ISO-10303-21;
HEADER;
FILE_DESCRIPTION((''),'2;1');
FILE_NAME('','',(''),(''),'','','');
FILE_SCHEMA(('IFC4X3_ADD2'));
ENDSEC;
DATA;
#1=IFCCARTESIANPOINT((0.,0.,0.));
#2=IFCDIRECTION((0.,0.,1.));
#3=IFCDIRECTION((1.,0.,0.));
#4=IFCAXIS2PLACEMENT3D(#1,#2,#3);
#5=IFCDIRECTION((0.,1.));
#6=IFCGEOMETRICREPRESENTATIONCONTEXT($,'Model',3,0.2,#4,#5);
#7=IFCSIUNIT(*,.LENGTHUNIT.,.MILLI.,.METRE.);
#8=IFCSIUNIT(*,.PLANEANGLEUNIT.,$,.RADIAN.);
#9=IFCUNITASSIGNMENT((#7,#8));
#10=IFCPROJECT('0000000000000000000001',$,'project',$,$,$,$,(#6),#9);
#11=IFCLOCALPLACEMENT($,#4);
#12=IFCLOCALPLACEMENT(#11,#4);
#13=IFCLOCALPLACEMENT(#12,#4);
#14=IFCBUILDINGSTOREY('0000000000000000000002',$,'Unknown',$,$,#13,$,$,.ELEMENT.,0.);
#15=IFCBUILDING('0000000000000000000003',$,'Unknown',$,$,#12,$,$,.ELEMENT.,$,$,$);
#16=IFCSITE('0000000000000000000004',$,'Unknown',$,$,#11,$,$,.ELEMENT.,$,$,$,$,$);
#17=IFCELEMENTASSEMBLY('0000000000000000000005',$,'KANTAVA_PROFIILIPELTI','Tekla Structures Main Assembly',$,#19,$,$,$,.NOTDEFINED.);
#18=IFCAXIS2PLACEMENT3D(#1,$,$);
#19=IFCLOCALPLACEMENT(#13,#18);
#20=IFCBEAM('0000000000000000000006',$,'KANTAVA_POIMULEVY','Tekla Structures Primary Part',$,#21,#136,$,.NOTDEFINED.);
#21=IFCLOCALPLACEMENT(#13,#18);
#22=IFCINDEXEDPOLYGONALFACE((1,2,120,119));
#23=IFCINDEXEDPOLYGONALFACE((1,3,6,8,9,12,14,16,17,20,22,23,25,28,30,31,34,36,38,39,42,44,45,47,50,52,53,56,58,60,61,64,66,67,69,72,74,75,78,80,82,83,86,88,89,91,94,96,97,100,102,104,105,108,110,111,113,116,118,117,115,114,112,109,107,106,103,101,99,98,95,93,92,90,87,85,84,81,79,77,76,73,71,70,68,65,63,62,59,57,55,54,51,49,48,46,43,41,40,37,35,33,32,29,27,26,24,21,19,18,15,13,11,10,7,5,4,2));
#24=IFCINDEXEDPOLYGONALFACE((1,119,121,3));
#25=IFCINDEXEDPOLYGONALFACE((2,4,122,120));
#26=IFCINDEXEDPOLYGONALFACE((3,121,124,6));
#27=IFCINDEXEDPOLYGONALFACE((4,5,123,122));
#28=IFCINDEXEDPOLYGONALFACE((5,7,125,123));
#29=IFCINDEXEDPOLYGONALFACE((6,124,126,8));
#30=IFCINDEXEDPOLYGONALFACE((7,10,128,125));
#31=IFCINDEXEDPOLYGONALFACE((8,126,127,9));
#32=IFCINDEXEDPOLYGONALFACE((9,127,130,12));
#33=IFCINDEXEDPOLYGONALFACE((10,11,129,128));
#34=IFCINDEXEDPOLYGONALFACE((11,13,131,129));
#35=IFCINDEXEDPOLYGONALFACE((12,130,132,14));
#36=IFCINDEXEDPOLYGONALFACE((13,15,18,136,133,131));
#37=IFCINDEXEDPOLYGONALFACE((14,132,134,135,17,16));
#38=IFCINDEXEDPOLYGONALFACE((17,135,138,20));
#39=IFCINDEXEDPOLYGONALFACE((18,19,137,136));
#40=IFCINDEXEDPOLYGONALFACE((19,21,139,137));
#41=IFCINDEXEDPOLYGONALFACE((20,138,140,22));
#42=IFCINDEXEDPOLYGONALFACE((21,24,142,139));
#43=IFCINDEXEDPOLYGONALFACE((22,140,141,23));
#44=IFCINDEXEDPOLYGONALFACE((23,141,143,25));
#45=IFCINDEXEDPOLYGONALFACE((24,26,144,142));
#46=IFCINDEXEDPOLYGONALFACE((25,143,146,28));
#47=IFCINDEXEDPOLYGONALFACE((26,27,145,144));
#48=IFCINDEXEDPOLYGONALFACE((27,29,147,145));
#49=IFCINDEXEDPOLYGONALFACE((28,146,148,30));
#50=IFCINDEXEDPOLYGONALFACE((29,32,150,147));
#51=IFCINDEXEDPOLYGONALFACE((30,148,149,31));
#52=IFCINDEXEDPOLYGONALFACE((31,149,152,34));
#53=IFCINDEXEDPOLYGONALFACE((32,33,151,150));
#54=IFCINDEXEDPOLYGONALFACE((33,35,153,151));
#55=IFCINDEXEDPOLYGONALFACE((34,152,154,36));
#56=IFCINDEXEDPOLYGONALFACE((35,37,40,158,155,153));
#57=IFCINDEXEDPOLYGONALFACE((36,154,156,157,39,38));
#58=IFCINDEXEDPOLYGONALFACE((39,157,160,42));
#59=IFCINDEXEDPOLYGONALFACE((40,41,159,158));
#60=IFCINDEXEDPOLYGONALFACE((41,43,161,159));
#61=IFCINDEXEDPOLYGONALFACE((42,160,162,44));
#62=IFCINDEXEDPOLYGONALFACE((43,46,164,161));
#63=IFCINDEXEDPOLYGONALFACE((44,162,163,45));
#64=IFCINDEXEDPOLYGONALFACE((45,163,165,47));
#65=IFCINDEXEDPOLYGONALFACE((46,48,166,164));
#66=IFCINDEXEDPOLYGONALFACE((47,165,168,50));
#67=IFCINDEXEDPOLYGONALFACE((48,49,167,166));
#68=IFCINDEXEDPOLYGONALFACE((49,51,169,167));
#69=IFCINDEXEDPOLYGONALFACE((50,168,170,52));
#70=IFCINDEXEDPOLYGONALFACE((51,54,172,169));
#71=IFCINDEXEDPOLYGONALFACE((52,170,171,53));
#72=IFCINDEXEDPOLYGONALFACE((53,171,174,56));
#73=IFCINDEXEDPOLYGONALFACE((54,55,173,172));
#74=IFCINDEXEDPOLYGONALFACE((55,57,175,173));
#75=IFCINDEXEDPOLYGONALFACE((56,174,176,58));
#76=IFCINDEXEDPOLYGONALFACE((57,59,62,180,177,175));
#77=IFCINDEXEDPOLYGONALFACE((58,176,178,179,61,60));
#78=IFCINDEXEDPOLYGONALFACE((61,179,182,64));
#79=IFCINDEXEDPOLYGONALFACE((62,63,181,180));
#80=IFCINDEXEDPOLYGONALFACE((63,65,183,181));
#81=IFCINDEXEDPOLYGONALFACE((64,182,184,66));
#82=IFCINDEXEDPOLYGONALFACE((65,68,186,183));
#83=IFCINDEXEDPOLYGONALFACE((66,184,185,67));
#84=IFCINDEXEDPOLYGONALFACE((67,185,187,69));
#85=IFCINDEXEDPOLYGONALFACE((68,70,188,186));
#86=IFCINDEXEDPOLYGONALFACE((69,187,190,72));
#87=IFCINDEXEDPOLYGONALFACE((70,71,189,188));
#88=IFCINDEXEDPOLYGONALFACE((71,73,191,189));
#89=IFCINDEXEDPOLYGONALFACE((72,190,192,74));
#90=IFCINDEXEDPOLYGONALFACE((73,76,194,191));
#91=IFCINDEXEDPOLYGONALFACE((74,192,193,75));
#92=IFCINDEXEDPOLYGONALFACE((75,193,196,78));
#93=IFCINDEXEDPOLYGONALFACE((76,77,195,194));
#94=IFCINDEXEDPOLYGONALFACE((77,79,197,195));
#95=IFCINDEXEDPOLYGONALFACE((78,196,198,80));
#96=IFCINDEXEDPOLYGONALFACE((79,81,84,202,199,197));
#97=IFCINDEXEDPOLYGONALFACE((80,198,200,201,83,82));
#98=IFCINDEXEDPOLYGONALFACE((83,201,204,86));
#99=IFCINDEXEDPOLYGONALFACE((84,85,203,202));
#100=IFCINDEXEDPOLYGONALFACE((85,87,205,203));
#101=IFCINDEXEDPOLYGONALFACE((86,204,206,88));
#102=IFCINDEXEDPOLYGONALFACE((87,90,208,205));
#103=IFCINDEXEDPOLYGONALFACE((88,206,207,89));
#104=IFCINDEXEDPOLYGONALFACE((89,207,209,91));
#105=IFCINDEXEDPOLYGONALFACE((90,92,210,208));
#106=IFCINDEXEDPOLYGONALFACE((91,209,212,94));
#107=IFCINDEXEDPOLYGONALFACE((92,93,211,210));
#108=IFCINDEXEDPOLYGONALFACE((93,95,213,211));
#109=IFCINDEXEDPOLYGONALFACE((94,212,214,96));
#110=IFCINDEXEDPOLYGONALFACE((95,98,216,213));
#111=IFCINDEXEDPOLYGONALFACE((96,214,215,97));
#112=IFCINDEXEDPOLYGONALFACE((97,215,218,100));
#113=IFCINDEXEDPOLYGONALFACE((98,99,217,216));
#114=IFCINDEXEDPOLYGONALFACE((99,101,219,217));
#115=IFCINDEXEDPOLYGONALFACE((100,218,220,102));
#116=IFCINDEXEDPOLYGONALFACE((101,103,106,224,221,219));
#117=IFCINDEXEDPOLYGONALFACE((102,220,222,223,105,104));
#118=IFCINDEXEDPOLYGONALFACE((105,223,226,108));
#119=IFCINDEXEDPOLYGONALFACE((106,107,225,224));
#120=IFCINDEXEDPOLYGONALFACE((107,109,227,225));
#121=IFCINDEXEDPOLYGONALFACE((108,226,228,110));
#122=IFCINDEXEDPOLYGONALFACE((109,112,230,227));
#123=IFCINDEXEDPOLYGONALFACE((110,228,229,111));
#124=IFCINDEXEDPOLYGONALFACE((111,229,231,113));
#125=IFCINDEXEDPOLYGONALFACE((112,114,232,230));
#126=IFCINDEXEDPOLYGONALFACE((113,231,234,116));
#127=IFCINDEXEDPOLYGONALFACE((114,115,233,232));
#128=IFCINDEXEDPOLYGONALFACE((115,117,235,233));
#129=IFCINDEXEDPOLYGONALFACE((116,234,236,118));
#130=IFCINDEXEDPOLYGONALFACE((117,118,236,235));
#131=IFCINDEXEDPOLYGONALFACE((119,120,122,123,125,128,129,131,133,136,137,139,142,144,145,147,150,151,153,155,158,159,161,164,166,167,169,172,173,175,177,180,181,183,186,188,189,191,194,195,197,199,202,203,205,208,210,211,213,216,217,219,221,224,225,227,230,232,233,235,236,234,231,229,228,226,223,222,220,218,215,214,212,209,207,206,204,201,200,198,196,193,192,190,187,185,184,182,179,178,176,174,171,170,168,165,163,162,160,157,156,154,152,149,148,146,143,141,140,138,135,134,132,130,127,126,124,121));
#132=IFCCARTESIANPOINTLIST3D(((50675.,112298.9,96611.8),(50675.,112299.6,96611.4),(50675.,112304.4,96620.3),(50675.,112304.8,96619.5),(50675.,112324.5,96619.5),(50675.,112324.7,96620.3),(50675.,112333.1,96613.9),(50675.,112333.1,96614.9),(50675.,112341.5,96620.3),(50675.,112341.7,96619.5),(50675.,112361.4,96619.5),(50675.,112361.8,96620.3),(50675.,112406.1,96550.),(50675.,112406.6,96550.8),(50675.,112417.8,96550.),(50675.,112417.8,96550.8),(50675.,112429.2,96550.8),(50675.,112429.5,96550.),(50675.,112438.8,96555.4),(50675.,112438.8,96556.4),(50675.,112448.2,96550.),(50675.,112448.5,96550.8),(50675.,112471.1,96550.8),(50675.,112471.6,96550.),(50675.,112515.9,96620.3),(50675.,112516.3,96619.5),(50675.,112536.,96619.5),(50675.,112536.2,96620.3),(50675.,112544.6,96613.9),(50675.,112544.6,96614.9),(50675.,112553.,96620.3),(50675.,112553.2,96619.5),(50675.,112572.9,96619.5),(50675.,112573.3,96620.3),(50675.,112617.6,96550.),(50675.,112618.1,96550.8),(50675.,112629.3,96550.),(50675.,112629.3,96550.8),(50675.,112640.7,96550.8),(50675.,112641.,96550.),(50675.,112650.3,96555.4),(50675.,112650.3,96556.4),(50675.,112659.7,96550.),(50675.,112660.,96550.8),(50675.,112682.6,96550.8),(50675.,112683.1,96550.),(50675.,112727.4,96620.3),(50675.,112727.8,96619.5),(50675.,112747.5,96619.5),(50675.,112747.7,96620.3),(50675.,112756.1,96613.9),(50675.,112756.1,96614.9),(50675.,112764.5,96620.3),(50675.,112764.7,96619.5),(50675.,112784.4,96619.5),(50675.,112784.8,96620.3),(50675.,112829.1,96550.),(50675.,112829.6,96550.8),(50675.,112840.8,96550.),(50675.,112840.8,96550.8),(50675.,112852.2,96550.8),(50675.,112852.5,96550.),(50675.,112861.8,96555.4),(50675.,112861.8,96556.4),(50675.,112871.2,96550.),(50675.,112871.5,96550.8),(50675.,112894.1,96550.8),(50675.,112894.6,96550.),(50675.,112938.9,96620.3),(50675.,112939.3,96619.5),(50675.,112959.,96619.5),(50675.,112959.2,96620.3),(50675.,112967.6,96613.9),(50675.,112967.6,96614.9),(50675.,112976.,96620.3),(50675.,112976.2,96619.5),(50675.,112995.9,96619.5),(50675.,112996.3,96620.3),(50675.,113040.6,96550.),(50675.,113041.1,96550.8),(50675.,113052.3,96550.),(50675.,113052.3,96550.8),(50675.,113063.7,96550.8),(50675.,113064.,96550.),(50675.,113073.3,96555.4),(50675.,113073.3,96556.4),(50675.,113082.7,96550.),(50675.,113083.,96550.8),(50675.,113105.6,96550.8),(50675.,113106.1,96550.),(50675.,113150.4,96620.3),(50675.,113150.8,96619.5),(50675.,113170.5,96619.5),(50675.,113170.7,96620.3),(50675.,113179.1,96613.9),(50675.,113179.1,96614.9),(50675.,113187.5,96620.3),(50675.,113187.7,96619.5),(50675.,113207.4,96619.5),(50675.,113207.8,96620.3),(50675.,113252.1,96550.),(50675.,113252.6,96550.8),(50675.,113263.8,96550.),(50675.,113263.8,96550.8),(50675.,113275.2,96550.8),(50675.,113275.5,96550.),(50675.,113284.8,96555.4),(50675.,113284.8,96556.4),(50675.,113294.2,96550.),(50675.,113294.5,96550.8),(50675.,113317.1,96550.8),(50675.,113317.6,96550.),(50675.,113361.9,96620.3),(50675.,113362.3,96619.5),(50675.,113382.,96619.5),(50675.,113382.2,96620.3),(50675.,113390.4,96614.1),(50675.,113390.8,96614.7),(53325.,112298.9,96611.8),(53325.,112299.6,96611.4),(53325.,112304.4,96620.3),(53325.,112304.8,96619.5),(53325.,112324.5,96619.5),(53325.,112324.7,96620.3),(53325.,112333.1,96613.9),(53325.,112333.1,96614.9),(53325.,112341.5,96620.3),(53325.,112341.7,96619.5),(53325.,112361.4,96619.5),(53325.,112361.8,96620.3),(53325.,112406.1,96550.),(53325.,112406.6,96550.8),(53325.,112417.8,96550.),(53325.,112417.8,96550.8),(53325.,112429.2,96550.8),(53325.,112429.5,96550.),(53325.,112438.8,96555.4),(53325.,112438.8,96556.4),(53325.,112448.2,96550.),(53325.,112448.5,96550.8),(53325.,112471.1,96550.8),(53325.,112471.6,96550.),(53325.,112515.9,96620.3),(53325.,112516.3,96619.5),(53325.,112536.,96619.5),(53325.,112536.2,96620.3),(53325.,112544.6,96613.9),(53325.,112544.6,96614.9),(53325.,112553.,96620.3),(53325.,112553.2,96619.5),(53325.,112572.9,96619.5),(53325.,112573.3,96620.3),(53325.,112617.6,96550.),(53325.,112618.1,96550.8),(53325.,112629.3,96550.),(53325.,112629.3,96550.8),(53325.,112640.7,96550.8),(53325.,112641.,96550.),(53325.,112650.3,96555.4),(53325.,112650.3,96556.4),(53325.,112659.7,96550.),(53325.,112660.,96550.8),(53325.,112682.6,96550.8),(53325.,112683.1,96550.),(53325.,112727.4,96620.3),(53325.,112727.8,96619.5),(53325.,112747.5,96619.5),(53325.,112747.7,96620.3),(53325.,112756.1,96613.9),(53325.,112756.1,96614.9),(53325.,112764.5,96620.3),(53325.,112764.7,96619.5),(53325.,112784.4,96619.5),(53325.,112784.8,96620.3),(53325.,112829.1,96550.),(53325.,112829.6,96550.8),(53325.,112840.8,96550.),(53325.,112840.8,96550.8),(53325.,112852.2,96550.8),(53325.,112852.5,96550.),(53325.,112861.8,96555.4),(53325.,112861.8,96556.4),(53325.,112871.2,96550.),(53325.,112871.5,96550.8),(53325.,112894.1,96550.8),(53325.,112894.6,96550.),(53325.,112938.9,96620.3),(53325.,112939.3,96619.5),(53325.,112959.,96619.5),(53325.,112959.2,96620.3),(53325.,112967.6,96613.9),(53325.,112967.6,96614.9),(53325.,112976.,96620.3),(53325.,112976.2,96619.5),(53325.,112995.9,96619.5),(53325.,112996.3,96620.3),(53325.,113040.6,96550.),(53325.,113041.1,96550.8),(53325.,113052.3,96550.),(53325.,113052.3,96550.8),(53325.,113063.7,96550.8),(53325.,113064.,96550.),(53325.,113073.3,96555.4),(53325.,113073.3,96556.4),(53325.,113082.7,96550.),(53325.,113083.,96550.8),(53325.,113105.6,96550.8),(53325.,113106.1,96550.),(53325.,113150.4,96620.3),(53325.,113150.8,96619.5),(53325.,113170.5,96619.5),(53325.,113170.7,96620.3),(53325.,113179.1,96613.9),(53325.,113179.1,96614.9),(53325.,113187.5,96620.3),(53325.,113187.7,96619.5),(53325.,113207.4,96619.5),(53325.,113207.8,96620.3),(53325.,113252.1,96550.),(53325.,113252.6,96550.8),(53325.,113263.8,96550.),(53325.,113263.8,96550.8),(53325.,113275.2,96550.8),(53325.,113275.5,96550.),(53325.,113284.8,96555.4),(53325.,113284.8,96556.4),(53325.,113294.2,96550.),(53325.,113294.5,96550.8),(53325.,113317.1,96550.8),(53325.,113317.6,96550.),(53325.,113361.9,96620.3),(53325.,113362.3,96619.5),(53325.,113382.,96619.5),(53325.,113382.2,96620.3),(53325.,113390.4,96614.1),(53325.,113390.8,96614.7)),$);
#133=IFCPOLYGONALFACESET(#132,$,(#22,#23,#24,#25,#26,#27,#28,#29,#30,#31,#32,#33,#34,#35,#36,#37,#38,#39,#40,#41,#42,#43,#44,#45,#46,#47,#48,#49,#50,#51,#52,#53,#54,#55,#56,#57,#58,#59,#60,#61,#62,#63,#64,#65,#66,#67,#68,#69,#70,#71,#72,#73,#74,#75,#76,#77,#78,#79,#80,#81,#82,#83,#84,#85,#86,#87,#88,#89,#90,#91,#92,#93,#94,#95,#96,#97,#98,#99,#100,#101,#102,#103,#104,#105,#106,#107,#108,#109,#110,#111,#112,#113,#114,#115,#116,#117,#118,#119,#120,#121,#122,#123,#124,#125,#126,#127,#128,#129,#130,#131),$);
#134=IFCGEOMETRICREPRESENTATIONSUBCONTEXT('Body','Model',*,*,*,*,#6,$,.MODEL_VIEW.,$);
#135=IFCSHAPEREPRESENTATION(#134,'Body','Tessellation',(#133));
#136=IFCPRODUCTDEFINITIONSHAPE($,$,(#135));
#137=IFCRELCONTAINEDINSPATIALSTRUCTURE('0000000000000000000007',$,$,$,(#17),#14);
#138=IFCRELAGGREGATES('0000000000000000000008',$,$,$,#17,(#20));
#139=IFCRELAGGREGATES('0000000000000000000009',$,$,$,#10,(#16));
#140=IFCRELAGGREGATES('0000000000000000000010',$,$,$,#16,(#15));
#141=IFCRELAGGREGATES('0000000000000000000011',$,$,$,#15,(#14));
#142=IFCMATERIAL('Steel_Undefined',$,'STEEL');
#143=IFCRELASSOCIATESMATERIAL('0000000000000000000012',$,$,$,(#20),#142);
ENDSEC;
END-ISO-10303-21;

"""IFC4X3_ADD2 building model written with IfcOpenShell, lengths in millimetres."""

from ifc_helpers import new_model, si_unit, direction, frame, origin_with_axes, place, context, subcontext, project, spatial, line, indexed_curve, outline, extrude, material, element, aggregate, save


model = new_model("IFC4X3_ADD2")

# Units and contexts
model_context = context("Model", 3, precision=0.2, world=origin_with_axes(), true_north=direction((0.0, 1.0)))
body_context = subcontext(model_context, "Body", "Model", "MODEL_VIEW")
ifc_project = project(units=[si_unit("LENGTHUNIT", "METRE", prefix="MILLI"), si_unit("PLANEANGLEUNIT", "RADIAN")], contexts=[model_context])

# Site, building, storey
site_placement = place(None, origin_with_axes())
site = spatial("IfcSite", under=ifc_project, at=site_placement, Name="Unknown", CompositionType="ELEMENT")
building_placement = place(site_placement, origin_with_axes())
building = spatial("IfcBuilding", under=site, at=building_placement, Name="Unknown", CompositionType="ELEMENT")
storey_placement = place(building_placement, origin_with_axes())
storey = spatial("IfcBuildingStorey", under=building, at=storey_placement, Name="Unknown", CompositionType="ELEMENT", Elevation=0.0)

# Element assembly, beam
ifc_material_1 = material(Name="Steel_Undefined", Category="STEEL")
assembly_1_placement = place(storey_placement, frame((53325.0, 112861.8, 96585.2), z_axis=(0.0, 1.0, 0.0), x_axis=(-1.0, 0.0, 0.0)))
assembly_1 = element("IfcElementAssembly", 1, at=assembly_1_placement, inside=storey, Name="KANTAVA_PROFIILIPELTI", Description="Tekla Structures Main Assembly", PredefinedType="NOTDEFINED")
beam_1_placement = place(assembly_1_placement, origin_with_axes())
beam_1 = element("IfcBeam", 2, at=beam_1_placement, material=ifc_material_1, Name="KANTAVA_POIMULEVY", Description="Tekla Structures Primary Part", PredefinedType="NOTDEFINED", context=body_context, shape_type="SolidModel", body=[
    extrude(outline(indexed_curve([(529.0, 29.6), (520.4, 35.1), (500.0, 35.1), (455.3, -34.4), (432.6, -34.4), (423.0, -28.8), (413.4, -34.4), (402.0, -34.4), (390.7, -34.4), (346.0, 35.1), (325.6, 35.1), (317.2, 29.7), (308.9, 35.1), (288.5, 35.1), (243.8, -34.4), (221.1, -34.4), (211.5, -28.8), (201.9, -34.4), (190.5, -34.4), (179.2, -34.4), (134.5, 35.1), (114.1, 35.1), (105.8, 29.7), (97.4, 35.1), (77.0, 35.1), (32.3, -34.4), (9.6, -34.4), (0.0, -28.8), (-9.6, -34.4), (-21.0, -34.4), (-32.3, -34.4), (-77.0, 35.1), (-97.4, 35.1), (-105.8, 29.7), (-114.1, 35.1), (-134.5, 35.1), (-179.2, -34.4), (-201.9, -34.4), (-211.5, -28.8), (-221.1, -34.4), (-232.5, -34.4), (-243.8, -34.4), (-288.5, 35.1), (-308.9, 35.1), (-317.2, 29.7), (-325.6, 35.1), (-346.0, 35.1), (-390.7, -34.4), (-413.4, -34.4), (-423.0, -28.8), (-432.6, -34.4), (-444.0, -34.4), (-455.3, -34.4), (-500.0, 35.1), (-520.4, 35.1), (-528.8, 29.7), (-537.1, 35.1), (-557.5, 35.1), (-562.9, 26.7), (-562.2, 26.2), (-557.0, 34.4), (-537.4, 34.4), (-528.8, 28.8), (-520.1, 34.4), (-500.5, 34.4), (-455.7, -35.1), (-444.0, -35.1), (-432.4, -35.1), (-423.0, -29.7), (-413.6, -35.1), (-390.3, -35.1), (-345.5, 34.4), (-325.9, 34.4), (-317.2, 28.8), (-308.6, 34.4), (-289.0, 34.4), (-244.2, -35.1), (-232.5, -35.1), (-220.9, -35.1), (-211.5, -29.7), (-202.1, -35.1), (-178.8, -35.1), (-134.0, 34.4), (-114.4, 34.4), (-105.8, 28.8), (-97.1, 34.4), (-77.5, 34.4), (-32.7, -35.1), (-21.0, -35.1), (-9.4, -35.1), (0.0, -29.7), (9.4, -35.1), (32.7, -35.1), (77.5, 34.4), (97.1, 34.4), (105.8, 28.8), (114.4, 34.4), (134.0, 34.4), (178.8, -35.1), (190.5, -35.1), (202.1, -35.1), (211.5, -29.7), (220.9, -35.1), (244.2, -35.1), (289.0, 34.4), (308.6, 34.4), (317.2, 28.8), (325.9, 34.4), (345.5, 34.4), (390.3, -35.1), (402.0, -35.1), (413.6, -35.1), (423.0, -29.7), (432.4, -35.1), (455.7, -35.1), (500.5, 34.4), (520.1, 34.4), (528.5, 28.9)], segments=[line(1, 2, 3, 4, 5, 6, 7, 8, 9, 10, 11, 12, 13, 14, 15, 16, 17, 18, 19, 20, 21, 22, 23, 24, 25, 26, 27, 28, 29, 30, 31, 32, 33, 34, 35, 36, 37, 38, 39, 40, 41, 42, 43, 44, 45, 46, 47, 48, 49, 50, 51, 52, 53, 54, 55, 56, 57, 58, 59, 60, 61, 62, 63, 64, 65, 66, 67, 68, 69, 70, 71, 72, 73, 74, 75, 76, 77, 78, 79, 80, 81, 82, 83, 84, 85, 86, 87, 88, 89, 90, 91, 92, 93, 94, 95, 96, 97, 98, 99, 100, 101, 102, 103, 104, 105, 106, 107, 108, 109, 110, 111, 112, 113, 114, 115, 116, 117, 118, 1)])), frame((0.0, 0.0, 0.0), z_axis=(-1.0, 0.0, 0.0), x_axis=(0.0, 0.0, 1.0)), (0.0, 0.0, -1.0), 2650.0),
])
aggregate(assembly_1, [beam_1])

save(model, "model.ifc")
